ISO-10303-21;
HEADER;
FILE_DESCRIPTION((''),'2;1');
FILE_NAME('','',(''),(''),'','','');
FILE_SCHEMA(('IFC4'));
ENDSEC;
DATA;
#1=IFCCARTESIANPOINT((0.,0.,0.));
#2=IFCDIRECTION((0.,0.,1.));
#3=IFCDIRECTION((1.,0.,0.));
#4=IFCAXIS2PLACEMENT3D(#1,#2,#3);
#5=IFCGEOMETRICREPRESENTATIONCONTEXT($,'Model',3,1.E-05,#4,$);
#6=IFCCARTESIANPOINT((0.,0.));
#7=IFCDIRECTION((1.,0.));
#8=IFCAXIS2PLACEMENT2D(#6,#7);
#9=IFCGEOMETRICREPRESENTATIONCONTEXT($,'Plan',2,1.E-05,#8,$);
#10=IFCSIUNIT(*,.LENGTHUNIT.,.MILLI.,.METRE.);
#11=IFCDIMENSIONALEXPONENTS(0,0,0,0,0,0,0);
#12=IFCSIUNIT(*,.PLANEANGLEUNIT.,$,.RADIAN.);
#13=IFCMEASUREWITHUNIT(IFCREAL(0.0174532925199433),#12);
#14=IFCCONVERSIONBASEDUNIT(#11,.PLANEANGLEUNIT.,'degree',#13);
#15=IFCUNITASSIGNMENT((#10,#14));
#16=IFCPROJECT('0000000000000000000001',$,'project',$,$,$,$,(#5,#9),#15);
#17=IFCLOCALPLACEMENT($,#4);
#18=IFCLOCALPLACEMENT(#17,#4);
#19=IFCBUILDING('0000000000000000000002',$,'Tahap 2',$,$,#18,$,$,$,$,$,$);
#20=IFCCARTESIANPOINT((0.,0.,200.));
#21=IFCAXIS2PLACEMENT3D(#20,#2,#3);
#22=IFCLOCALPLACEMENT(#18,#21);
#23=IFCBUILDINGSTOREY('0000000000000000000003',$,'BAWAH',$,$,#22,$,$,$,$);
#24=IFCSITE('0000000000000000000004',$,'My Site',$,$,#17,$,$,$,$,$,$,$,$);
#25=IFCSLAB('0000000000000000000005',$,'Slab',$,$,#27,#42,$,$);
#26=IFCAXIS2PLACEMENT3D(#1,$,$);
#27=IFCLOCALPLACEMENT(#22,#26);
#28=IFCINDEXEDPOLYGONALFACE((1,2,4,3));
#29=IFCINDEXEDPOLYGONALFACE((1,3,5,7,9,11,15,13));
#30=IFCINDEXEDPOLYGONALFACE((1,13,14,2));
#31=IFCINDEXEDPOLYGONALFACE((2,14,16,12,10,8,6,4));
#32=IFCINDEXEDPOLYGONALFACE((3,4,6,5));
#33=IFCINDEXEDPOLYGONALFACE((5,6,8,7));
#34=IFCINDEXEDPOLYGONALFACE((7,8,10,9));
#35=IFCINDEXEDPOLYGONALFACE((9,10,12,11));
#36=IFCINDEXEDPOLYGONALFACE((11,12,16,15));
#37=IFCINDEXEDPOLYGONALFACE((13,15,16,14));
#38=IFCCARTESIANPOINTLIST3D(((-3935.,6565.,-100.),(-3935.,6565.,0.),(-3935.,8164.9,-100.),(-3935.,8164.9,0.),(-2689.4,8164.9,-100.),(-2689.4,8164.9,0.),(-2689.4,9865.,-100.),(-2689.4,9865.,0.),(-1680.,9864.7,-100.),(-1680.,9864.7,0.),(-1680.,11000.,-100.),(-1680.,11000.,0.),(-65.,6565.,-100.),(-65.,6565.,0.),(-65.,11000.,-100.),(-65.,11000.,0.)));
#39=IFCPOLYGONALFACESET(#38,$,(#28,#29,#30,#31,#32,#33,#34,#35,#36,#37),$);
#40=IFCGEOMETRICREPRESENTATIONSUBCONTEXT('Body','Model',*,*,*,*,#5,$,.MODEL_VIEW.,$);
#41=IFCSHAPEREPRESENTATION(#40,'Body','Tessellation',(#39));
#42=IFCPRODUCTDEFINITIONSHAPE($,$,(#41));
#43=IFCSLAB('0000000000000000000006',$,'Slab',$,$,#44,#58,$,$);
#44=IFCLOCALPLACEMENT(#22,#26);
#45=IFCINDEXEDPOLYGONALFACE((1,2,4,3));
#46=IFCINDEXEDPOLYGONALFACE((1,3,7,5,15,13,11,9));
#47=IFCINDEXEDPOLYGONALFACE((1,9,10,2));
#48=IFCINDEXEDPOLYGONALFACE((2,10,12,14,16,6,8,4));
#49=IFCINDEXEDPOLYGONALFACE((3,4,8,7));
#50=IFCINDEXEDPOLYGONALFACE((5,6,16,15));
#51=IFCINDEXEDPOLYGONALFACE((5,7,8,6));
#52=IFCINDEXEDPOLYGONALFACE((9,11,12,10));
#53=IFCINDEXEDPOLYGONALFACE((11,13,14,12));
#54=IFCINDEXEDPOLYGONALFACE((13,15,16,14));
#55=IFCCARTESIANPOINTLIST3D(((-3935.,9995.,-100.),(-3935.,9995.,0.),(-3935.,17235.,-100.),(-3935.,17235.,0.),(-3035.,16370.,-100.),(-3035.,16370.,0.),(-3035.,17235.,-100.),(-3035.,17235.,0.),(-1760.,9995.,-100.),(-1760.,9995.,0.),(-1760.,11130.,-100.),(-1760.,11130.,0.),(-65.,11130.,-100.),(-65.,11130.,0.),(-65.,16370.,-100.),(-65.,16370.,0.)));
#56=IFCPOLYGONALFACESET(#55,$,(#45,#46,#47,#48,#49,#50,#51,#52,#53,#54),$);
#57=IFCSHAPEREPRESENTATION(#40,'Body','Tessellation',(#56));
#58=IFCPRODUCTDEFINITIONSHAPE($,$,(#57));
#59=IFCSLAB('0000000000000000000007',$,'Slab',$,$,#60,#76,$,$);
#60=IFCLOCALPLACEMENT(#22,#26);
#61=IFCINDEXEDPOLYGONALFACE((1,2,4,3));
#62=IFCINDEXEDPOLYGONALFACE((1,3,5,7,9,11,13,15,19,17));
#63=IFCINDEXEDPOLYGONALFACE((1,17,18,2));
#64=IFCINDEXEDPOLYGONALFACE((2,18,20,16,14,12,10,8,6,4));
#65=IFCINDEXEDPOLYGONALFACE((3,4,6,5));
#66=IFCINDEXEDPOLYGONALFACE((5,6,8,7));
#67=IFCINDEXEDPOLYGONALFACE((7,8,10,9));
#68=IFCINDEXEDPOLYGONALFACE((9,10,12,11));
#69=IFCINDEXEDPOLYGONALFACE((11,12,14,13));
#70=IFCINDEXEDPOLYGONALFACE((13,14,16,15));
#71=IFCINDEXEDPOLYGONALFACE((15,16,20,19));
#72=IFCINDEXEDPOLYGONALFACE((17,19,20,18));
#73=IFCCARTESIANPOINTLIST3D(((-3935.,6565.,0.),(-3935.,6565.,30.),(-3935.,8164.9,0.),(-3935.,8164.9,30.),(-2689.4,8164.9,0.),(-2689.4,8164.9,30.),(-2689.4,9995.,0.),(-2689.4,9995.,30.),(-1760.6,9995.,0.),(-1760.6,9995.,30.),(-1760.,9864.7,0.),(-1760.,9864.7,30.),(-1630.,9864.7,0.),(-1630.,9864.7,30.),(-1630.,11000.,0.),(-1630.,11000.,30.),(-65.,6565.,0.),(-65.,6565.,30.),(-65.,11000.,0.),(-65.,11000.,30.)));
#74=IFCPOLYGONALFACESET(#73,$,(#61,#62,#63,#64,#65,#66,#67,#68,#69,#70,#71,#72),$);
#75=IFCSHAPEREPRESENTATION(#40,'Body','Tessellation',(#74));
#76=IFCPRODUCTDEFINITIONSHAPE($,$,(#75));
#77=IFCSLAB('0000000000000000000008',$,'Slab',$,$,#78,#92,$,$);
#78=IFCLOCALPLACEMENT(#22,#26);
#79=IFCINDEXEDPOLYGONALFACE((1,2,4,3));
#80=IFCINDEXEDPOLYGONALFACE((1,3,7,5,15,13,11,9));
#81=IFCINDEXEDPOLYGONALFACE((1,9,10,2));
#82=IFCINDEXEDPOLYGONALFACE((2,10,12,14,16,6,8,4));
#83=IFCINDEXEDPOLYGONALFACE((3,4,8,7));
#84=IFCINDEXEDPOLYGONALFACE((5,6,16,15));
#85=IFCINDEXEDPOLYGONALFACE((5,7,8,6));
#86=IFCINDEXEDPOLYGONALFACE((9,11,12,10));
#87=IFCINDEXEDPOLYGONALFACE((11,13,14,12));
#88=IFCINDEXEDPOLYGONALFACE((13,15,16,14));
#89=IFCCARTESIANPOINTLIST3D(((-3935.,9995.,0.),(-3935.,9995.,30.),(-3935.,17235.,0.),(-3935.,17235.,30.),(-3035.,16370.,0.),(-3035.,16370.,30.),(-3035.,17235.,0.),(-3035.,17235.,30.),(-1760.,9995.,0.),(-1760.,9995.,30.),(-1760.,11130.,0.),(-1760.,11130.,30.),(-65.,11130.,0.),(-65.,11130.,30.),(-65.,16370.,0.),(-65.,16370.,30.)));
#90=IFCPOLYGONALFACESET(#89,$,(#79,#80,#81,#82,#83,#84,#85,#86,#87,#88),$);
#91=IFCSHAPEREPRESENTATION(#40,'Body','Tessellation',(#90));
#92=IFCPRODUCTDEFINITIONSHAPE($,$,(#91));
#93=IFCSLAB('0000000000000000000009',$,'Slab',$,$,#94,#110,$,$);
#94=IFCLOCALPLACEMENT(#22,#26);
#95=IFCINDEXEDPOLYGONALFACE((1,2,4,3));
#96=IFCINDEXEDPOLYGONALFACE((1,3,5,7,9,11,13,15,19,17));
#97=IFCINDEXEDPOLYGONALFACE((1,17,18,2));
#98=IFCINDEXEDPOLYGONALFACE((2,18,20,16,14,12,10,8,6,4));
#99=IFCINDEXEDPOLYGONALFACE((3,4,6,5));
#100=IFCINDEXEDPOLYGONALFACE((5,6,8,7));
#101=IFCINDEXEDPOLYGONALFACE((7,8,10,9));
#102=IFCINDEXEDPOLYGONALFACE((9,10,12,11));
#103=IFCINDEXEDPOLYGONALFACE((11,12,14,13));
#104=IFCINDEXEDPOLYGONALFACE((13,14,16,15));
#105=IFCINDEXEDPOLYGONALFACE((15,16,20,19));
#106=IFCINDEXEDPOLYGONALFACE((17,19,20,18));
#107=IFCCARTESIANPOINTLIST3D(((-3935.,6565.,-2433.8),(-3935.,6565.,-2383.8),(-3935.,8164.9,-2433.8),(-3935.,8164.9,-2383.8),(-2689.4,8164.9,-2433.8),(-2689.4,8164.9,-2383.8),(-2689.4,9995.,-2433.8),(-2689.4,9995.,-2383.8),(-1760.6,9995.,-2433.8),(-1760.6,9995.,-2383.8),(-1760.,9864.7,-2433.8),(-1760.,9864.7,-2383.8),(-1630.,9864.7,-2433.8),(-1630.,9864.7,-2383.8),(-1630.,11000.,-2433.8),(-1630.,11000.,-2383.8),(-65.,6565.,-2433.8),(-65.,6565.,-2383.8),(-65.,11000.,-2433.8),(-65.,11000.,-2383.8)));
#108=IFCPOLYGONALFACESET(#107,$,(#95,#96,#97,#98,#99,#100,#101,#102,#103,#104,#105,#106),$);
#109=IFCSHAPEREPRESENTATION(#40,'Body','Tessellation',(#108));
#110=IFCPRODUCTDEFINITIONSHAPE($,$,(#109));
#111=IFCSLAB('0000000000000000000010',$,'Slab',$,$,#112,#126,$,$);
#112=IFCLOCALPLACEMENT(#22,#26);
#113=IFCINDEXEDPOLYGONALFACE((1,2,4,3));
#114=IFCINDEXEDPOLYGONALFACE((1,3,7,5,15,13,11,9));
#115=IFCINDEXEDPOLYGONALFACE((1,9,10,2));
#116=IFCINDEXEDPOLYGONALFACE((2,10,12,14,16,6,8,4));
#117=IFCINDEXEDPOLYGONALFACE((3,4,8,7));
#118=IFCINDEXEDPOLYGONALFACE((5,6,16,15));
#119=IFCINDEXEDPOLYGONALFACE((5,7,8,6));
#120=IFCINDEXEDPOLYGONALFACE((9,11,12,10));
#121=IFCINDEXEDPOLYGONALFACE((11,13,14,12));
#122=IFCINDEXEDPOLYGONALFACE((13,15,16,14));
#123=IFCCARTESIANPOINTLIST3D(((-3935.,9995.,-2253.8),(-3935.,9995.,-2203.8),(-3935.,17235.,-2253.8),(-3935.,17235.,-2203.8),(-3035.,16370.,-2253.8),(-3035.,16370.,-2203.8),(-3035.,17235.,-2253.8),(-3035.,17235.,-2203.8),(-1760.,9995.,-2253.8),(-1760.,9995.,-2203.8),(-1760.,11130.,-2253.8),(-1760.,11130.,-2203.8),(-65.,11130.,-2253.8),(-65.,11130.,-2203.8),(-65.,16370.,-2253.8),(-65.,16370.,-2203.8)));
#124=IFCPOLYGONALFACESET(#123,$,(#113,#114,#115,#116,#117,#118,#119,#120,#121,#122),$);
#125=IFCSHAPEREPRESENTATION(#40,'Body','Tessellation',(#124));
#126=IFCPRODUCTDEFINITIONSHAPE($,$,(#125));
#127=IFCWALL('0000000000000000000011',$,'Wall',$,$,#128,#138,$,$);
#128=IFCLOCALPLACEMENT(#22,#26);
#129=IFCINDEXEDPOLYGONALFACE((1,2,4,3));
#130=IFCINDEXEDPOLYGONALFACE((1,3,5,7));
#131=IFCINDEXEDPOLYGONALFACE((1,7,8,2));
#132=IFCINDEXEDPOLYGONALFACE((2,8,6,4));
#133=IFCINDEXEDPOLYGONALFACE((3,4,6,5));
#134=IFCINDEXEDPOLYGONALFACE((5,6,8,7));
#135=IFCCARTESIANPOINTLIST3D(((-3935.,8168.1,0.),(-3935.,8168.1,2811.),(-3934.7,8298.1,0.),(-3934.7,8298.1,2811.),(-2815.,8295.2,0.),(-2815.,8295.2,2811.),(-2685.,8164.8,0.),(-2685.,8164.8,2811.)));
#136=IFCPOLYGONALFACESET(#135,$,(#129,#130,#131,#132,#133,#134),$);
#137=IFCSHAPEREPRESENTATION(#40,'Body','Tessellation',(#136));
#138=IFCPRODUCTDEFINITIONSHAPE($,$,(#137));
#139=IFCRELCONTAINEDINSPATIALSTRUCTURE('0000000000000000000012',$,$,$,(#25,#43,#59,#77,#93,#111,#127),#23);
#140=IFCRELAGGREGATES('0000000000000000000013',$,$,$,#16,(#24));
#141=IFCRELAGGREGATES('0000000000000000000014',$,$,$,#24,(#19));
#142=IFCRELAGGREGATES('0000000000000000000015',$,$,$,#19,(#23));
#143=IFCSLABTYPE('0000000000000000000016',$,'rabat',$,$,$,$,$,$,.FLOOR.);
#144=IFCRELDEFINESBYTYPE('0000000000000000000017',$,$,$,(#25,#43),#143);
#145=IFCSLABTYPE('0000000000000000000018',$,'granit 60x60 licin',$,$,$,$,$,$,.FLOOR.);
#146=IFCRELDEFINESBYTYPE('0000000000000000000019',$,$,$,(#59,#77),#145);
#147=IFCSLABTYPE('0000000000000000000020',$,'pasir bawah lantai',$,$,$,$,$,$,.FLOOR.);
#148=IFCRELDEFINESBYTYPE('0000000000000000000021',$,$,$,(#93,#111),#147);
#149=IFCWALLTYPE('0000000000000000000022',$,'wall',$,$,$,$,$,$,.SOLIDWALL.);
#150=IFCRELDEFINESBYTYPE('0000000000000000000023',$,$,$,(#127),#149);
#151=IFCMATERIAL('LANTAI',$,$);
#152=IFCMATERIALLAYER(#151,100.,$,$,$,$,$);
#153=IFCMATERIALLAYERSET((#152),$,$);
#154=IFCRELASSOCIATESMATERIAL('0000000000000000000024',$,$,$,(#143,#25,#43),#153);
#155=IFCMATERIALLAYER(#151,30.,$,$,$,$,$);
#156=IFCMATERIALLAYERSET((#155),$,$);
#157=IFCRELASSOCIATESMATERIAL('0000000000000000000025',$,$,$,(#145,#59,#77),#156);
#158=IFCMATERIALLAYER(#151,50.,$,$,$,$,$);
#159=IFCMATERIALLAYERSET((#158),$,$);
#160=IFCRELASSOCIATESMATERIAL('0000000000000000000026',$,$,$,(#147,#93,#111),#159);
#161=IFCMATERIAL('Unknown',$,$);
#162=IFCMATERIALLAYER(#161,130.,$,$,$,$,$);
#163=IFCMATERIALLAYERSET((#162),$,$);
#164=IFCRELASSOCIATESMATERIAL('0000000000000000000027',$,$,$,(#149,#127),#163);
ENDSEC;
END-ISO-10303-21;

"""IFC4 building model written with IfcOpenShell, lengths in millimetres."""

from ifc_helpers import new_model, entity, si_unit, converted_unit, frame, origin_with_axes, origin_2d_with_axis, place, context, subcontext, project, spatial, line, indexed_curve, outline, extrude, material, layer, layer_set, layer_usage, type_object, element, save


model = new_model("IFC4")

# Units and contexts
model_context = context("Model", 3, precision=1e-05, world=origin_with_axes())
plan_context = context("Plan", 2, precision=1e-05, world=origin_2d_with_axis())
body_context_1 = subcontext(model_context, "Body", "Model", "MODEL_VIEW")
ifc_project = project(units=[si_unit("LENGTHUNIT", "METRE", prefix="MILLI"), converted_unit("PLANEANGLEUNIT", "degree", entity("IfcReal", 0.0174532925199433), si_unit("PLANEANGLEUNIT", "RADIAN"), dimensions=[0, 0, 0, 0, 0, 0, 0])], contexts=[model_context, plan_context])

# Site, building, storey
site_placement = place(None, origin_with_axes())
site = spatial("IfcSite", under=ifc_project, at=site_placement, Name="My Site")
building_placement = place(site_placement, origin_with_axes())
building = spatial("IfcBuilding", under=site, at=building_placement, Name="Tahap 2")
storey_placement = place(building_placement, frame((0.0, 0.0, 200.0), z_axis=(0.0, 0.0, 1.0), x_axis=(1.0, 0.0, 0.0)))
storey = spatial("IfcBuildingStorey", under=building, at=storey_placement, Name="BAWAH")

# Slabs
ifc_material_1 = material(Name="LANTAI")
ifc_layer_1 = layer(ifc_material_1, 100.0)
ifc_layer_set_1 = layer_set([ifc_layer_1])
ifc_layer_usage_1 = layer_usage(ifc_layer_set_1, "AXIS3", "NEGATIVE", 0.0)
slab_type_1 = type_object("IfcSlabType", Name="rabat", PredefinedType="FLOOR", material=ifc_layer_set_1)
slab_1_placement = place(storey_placement, frame((-3935.0, 6565.0, 0.0), z_axis=(0.0, 0.0, 1.0), x_axis=(1.0, 0.0, 0.0)))
element("IfcSlab", 1, at=slab_1_placement, inside=storey, type_object=slab_type_1, material=ifc_layer_usage_1, Name="Slab", context=body_context_1, shape_type="SweptSolid", body=[
    extrude(outline(indexed_curve([(3870.0, 0.0), (3870.0, 4435.0), (2255.0, 4435.0), (2255.0, 3299.7), (1245.6, 3300.0), (1245.6, 1599.9), (0.0, 1599.9), (0.0, 0.0), (3870.0, 0.0)])), None, (0.0, 0.0, -1.0), 100.0),
])
ifc_layer_usage_2 = layer_usage(ifc_layer_set_1, "AXIS3", "NEGATIVE", 0.0)
slab_2_placement = place(storey_placement, frame((-3935.0, 9995.0, 0.0), z_axis=(0.0, 0.0, 1.0), x_axis=(1.0, 0.0, 0.0)))
element("IfcSlab", 2, at=slab_2_placement, inside=storey, type_object=slab_type_1, material=ifc_layer_usage_2, Name="Slab", context=body_context_1, shape_type="SweptSolid", body=[
    extrude(outline(indexed_curve([(0.0, 0.0), (2175.0, 0.0), (2175.0, 1135.0), (3870.0, 1135.0), (3870.0, 6375.0), (900.0, 6375.0), (900.0, 7240.0), (0.0, 7240.0), (0.0, 0.0)])), None, (0.0, 0.0, -1.0), 100.0),
])
ifc_layer_2 = layer(ifc_material_1, 30.0)
ifc_layer_set_2 = layer_set([ifc_layer_2])
ifc_layer_usage_3 = layer_usage(ifc_layer_set_2, "AXIS3", "POSITIVE", 0.0)
slab_type_2 = type_object("IfcSlabType", Name="granit 60x60 licin", PredefinedType="FLOOR", material=ifc_layer_set_2)
slab_3_placement = place(storey_placement, frame((-3935.0, 6565.0, 0.0), z_axis=(0.0, 0.0, 1.0), x_axis=(1.0, 0.0, 0.0)))
element("IfcSlab", 3, at=slab_3_placement, inside=storey, type_object=slab_type_2, material=ifc_layer_usage_3, Name="Slab", context=body_context_1, shape_type="SweptSolid", body=[
    extrude(outline(indexed_curve([(0.0, 0.0), (0.0, 1599.9), (1245.6, 1599.9), (1245.6, 3430.0), (2174.4, 3430.0), (2175.0, 3299.7), (2305.0, 3299.7), (2305.0, 4435.0), (3870.0, 4435.0), (3870.0, 0.0), (0.0, 0.0)])), None, (0.0, 0.0, 1.0), 30.0),
])
ifc_layer_usage_4 = layer_usage(ifc_layer_set_2, "AXIS3", "POSITIVE", 0.0)
slab_4_placement = place(storey_placement, frame((-3935.0, 9995.0, 0.0), z_axis=(0.0, 0.0, 1.0), x_axis=(1.0, 0.0, 0.0)))
element("IfcSlab", 4, at=slab_4_placement, inside=storey, type_object=slab_type_2, material=ifc_layer_usage_4, Name="Slab", context=body_context_1, shape_type="SweptSolid", body=[
    extrude(outline(indexed_curve([(0.0, 0.0), (2175.0, 0.0), (2175.0, 1135.0), (3870.0, 1135.0), (3870.0, 6375.0), (900.0, 6375.0), (900.0, 7240.0), (0.0, 7240.0), (0.0, 0.0)])), None, (0.0, 0.0, 1.0), 30.0),
])
ifc_layer_3 = layer(ifc_material_1, 50.0)
ifc_layer_set_3 = layer_set([ifc_layer_3])
ifc_layer_usage_5 = layer_usage(ifc_layer_set_3, "AXIS3", "POSITIVE", -50.0)
slab_type_3 = type_object("IfcSlabType", Name="pasir bawah lantai", PredefinedType="FLOOR", material=ifc_layer_set_3)
slab_5_placement = place(storey_placement, frame((-3935.0, 6565.0, -2383.8), z_axis=(0.0, 0.0, 1.0), x_axis=(1.0, 0.0, 0.0)))
element("IfcSlab", 5, at=slab_5_placement, inside=storey, type_object=slab_type_3, material=ifc_layer_usage_5, Name="Slab", context=body_context_1, shape_type="SweptSolid", body=[
    extrude(outline(indexed_curve([(0.0, 0.0), (0.0, 1599.9), (1245.6, 1599.9), (1245.6, 3430.0), (2174.4, 3430.0), (2175.0, 3299.7), (2305.0, 3299.7), (2305.0, 4435.0), (3870.0, 4435.0), (3870.0, 0.0), (0.0, 0.0)])), frame((0.0, 0.0, -50.0), z_axis=(0.0, 0.0, 1.0), x_axis=(1.0, 0.0, 0.0)), (0.0, 0.0, 1.0), 50.0),
])
ifc_layer_usage_6 = layer_usage(ifc_layer_set_3, "AXIS3", "POSITIVE", -50.0)
slab_6_placement = place(storey_placement, frame((-3935.0, 9995.0, -2203.8), z_axis=(0.0, 0.0, 1.0), x_axis=(1.0, 0.0, 0.0)))
element("IfcSlab", 6, at=slab_6_placement, inside=storey, type_object=slab_type_3, material=ifc_layer_usage_6, Name="Slab", context=body_context_1, shape_type="SweptSolid", body=[
    extrude(outline(indexed_curve([(0.0, 0.0), (2175.0, 0.0), (2175.0, 1135.0), (3870.0, 1135.0), (3870.0, 6375.0), (900.0, 6375.0), (900.0, 7240.0), (0.0, 7240.0), (0.0, 0.0)])), frame((0.0, 0.0, -50.0), z_axis=(0.0, 0.0, 1.0), x_axis=(1.0, 0.0, 0.0)), (0.0, 0.0, 1.0), 50.0),
])

# Wall
ifc_material_2 = material(Name="Unknown")
ifc_layer_4 = layer(ifc_material_2, 130.0)
ifc_layer_set_4 = layer_set([ifc_layer_4])
ifc_layer_usage_7 = layer_usage(ifc_layer_set_4, "AXIS2", "POSITIVE", 0.0)
wall_type = type_object("IfcWallType", Name="wall", PredefinedType="SOLIDWALL", material=ifc_layer_set_4)
wall_1_placement = place(storey_placement, frame((-3935.0, 8168.1, 0.0), z_axis=(0.0, 0.0, 1.0), x_axis=(0.999997, -0.002566, 0.0)))
element("IfcWall", 7, at=wall_1_placement, inside=storey, type_object=wall_type, material=ifc_layer_usage_7, Name="Wall", context=body_context_1, shape_type="SweptSolid", body=[
    extrude(outline(indexed_curve([(0.0, 0.0), (0.0, 130.0), (1119.7, 130.0), (1250.0, 0.0)], segments=[line(1, 2, 3, 4, 1)])), origin_with_axes(), (0.0, 0.0, 1.0), 2811.0),
])

save(model, "model.ifc")
